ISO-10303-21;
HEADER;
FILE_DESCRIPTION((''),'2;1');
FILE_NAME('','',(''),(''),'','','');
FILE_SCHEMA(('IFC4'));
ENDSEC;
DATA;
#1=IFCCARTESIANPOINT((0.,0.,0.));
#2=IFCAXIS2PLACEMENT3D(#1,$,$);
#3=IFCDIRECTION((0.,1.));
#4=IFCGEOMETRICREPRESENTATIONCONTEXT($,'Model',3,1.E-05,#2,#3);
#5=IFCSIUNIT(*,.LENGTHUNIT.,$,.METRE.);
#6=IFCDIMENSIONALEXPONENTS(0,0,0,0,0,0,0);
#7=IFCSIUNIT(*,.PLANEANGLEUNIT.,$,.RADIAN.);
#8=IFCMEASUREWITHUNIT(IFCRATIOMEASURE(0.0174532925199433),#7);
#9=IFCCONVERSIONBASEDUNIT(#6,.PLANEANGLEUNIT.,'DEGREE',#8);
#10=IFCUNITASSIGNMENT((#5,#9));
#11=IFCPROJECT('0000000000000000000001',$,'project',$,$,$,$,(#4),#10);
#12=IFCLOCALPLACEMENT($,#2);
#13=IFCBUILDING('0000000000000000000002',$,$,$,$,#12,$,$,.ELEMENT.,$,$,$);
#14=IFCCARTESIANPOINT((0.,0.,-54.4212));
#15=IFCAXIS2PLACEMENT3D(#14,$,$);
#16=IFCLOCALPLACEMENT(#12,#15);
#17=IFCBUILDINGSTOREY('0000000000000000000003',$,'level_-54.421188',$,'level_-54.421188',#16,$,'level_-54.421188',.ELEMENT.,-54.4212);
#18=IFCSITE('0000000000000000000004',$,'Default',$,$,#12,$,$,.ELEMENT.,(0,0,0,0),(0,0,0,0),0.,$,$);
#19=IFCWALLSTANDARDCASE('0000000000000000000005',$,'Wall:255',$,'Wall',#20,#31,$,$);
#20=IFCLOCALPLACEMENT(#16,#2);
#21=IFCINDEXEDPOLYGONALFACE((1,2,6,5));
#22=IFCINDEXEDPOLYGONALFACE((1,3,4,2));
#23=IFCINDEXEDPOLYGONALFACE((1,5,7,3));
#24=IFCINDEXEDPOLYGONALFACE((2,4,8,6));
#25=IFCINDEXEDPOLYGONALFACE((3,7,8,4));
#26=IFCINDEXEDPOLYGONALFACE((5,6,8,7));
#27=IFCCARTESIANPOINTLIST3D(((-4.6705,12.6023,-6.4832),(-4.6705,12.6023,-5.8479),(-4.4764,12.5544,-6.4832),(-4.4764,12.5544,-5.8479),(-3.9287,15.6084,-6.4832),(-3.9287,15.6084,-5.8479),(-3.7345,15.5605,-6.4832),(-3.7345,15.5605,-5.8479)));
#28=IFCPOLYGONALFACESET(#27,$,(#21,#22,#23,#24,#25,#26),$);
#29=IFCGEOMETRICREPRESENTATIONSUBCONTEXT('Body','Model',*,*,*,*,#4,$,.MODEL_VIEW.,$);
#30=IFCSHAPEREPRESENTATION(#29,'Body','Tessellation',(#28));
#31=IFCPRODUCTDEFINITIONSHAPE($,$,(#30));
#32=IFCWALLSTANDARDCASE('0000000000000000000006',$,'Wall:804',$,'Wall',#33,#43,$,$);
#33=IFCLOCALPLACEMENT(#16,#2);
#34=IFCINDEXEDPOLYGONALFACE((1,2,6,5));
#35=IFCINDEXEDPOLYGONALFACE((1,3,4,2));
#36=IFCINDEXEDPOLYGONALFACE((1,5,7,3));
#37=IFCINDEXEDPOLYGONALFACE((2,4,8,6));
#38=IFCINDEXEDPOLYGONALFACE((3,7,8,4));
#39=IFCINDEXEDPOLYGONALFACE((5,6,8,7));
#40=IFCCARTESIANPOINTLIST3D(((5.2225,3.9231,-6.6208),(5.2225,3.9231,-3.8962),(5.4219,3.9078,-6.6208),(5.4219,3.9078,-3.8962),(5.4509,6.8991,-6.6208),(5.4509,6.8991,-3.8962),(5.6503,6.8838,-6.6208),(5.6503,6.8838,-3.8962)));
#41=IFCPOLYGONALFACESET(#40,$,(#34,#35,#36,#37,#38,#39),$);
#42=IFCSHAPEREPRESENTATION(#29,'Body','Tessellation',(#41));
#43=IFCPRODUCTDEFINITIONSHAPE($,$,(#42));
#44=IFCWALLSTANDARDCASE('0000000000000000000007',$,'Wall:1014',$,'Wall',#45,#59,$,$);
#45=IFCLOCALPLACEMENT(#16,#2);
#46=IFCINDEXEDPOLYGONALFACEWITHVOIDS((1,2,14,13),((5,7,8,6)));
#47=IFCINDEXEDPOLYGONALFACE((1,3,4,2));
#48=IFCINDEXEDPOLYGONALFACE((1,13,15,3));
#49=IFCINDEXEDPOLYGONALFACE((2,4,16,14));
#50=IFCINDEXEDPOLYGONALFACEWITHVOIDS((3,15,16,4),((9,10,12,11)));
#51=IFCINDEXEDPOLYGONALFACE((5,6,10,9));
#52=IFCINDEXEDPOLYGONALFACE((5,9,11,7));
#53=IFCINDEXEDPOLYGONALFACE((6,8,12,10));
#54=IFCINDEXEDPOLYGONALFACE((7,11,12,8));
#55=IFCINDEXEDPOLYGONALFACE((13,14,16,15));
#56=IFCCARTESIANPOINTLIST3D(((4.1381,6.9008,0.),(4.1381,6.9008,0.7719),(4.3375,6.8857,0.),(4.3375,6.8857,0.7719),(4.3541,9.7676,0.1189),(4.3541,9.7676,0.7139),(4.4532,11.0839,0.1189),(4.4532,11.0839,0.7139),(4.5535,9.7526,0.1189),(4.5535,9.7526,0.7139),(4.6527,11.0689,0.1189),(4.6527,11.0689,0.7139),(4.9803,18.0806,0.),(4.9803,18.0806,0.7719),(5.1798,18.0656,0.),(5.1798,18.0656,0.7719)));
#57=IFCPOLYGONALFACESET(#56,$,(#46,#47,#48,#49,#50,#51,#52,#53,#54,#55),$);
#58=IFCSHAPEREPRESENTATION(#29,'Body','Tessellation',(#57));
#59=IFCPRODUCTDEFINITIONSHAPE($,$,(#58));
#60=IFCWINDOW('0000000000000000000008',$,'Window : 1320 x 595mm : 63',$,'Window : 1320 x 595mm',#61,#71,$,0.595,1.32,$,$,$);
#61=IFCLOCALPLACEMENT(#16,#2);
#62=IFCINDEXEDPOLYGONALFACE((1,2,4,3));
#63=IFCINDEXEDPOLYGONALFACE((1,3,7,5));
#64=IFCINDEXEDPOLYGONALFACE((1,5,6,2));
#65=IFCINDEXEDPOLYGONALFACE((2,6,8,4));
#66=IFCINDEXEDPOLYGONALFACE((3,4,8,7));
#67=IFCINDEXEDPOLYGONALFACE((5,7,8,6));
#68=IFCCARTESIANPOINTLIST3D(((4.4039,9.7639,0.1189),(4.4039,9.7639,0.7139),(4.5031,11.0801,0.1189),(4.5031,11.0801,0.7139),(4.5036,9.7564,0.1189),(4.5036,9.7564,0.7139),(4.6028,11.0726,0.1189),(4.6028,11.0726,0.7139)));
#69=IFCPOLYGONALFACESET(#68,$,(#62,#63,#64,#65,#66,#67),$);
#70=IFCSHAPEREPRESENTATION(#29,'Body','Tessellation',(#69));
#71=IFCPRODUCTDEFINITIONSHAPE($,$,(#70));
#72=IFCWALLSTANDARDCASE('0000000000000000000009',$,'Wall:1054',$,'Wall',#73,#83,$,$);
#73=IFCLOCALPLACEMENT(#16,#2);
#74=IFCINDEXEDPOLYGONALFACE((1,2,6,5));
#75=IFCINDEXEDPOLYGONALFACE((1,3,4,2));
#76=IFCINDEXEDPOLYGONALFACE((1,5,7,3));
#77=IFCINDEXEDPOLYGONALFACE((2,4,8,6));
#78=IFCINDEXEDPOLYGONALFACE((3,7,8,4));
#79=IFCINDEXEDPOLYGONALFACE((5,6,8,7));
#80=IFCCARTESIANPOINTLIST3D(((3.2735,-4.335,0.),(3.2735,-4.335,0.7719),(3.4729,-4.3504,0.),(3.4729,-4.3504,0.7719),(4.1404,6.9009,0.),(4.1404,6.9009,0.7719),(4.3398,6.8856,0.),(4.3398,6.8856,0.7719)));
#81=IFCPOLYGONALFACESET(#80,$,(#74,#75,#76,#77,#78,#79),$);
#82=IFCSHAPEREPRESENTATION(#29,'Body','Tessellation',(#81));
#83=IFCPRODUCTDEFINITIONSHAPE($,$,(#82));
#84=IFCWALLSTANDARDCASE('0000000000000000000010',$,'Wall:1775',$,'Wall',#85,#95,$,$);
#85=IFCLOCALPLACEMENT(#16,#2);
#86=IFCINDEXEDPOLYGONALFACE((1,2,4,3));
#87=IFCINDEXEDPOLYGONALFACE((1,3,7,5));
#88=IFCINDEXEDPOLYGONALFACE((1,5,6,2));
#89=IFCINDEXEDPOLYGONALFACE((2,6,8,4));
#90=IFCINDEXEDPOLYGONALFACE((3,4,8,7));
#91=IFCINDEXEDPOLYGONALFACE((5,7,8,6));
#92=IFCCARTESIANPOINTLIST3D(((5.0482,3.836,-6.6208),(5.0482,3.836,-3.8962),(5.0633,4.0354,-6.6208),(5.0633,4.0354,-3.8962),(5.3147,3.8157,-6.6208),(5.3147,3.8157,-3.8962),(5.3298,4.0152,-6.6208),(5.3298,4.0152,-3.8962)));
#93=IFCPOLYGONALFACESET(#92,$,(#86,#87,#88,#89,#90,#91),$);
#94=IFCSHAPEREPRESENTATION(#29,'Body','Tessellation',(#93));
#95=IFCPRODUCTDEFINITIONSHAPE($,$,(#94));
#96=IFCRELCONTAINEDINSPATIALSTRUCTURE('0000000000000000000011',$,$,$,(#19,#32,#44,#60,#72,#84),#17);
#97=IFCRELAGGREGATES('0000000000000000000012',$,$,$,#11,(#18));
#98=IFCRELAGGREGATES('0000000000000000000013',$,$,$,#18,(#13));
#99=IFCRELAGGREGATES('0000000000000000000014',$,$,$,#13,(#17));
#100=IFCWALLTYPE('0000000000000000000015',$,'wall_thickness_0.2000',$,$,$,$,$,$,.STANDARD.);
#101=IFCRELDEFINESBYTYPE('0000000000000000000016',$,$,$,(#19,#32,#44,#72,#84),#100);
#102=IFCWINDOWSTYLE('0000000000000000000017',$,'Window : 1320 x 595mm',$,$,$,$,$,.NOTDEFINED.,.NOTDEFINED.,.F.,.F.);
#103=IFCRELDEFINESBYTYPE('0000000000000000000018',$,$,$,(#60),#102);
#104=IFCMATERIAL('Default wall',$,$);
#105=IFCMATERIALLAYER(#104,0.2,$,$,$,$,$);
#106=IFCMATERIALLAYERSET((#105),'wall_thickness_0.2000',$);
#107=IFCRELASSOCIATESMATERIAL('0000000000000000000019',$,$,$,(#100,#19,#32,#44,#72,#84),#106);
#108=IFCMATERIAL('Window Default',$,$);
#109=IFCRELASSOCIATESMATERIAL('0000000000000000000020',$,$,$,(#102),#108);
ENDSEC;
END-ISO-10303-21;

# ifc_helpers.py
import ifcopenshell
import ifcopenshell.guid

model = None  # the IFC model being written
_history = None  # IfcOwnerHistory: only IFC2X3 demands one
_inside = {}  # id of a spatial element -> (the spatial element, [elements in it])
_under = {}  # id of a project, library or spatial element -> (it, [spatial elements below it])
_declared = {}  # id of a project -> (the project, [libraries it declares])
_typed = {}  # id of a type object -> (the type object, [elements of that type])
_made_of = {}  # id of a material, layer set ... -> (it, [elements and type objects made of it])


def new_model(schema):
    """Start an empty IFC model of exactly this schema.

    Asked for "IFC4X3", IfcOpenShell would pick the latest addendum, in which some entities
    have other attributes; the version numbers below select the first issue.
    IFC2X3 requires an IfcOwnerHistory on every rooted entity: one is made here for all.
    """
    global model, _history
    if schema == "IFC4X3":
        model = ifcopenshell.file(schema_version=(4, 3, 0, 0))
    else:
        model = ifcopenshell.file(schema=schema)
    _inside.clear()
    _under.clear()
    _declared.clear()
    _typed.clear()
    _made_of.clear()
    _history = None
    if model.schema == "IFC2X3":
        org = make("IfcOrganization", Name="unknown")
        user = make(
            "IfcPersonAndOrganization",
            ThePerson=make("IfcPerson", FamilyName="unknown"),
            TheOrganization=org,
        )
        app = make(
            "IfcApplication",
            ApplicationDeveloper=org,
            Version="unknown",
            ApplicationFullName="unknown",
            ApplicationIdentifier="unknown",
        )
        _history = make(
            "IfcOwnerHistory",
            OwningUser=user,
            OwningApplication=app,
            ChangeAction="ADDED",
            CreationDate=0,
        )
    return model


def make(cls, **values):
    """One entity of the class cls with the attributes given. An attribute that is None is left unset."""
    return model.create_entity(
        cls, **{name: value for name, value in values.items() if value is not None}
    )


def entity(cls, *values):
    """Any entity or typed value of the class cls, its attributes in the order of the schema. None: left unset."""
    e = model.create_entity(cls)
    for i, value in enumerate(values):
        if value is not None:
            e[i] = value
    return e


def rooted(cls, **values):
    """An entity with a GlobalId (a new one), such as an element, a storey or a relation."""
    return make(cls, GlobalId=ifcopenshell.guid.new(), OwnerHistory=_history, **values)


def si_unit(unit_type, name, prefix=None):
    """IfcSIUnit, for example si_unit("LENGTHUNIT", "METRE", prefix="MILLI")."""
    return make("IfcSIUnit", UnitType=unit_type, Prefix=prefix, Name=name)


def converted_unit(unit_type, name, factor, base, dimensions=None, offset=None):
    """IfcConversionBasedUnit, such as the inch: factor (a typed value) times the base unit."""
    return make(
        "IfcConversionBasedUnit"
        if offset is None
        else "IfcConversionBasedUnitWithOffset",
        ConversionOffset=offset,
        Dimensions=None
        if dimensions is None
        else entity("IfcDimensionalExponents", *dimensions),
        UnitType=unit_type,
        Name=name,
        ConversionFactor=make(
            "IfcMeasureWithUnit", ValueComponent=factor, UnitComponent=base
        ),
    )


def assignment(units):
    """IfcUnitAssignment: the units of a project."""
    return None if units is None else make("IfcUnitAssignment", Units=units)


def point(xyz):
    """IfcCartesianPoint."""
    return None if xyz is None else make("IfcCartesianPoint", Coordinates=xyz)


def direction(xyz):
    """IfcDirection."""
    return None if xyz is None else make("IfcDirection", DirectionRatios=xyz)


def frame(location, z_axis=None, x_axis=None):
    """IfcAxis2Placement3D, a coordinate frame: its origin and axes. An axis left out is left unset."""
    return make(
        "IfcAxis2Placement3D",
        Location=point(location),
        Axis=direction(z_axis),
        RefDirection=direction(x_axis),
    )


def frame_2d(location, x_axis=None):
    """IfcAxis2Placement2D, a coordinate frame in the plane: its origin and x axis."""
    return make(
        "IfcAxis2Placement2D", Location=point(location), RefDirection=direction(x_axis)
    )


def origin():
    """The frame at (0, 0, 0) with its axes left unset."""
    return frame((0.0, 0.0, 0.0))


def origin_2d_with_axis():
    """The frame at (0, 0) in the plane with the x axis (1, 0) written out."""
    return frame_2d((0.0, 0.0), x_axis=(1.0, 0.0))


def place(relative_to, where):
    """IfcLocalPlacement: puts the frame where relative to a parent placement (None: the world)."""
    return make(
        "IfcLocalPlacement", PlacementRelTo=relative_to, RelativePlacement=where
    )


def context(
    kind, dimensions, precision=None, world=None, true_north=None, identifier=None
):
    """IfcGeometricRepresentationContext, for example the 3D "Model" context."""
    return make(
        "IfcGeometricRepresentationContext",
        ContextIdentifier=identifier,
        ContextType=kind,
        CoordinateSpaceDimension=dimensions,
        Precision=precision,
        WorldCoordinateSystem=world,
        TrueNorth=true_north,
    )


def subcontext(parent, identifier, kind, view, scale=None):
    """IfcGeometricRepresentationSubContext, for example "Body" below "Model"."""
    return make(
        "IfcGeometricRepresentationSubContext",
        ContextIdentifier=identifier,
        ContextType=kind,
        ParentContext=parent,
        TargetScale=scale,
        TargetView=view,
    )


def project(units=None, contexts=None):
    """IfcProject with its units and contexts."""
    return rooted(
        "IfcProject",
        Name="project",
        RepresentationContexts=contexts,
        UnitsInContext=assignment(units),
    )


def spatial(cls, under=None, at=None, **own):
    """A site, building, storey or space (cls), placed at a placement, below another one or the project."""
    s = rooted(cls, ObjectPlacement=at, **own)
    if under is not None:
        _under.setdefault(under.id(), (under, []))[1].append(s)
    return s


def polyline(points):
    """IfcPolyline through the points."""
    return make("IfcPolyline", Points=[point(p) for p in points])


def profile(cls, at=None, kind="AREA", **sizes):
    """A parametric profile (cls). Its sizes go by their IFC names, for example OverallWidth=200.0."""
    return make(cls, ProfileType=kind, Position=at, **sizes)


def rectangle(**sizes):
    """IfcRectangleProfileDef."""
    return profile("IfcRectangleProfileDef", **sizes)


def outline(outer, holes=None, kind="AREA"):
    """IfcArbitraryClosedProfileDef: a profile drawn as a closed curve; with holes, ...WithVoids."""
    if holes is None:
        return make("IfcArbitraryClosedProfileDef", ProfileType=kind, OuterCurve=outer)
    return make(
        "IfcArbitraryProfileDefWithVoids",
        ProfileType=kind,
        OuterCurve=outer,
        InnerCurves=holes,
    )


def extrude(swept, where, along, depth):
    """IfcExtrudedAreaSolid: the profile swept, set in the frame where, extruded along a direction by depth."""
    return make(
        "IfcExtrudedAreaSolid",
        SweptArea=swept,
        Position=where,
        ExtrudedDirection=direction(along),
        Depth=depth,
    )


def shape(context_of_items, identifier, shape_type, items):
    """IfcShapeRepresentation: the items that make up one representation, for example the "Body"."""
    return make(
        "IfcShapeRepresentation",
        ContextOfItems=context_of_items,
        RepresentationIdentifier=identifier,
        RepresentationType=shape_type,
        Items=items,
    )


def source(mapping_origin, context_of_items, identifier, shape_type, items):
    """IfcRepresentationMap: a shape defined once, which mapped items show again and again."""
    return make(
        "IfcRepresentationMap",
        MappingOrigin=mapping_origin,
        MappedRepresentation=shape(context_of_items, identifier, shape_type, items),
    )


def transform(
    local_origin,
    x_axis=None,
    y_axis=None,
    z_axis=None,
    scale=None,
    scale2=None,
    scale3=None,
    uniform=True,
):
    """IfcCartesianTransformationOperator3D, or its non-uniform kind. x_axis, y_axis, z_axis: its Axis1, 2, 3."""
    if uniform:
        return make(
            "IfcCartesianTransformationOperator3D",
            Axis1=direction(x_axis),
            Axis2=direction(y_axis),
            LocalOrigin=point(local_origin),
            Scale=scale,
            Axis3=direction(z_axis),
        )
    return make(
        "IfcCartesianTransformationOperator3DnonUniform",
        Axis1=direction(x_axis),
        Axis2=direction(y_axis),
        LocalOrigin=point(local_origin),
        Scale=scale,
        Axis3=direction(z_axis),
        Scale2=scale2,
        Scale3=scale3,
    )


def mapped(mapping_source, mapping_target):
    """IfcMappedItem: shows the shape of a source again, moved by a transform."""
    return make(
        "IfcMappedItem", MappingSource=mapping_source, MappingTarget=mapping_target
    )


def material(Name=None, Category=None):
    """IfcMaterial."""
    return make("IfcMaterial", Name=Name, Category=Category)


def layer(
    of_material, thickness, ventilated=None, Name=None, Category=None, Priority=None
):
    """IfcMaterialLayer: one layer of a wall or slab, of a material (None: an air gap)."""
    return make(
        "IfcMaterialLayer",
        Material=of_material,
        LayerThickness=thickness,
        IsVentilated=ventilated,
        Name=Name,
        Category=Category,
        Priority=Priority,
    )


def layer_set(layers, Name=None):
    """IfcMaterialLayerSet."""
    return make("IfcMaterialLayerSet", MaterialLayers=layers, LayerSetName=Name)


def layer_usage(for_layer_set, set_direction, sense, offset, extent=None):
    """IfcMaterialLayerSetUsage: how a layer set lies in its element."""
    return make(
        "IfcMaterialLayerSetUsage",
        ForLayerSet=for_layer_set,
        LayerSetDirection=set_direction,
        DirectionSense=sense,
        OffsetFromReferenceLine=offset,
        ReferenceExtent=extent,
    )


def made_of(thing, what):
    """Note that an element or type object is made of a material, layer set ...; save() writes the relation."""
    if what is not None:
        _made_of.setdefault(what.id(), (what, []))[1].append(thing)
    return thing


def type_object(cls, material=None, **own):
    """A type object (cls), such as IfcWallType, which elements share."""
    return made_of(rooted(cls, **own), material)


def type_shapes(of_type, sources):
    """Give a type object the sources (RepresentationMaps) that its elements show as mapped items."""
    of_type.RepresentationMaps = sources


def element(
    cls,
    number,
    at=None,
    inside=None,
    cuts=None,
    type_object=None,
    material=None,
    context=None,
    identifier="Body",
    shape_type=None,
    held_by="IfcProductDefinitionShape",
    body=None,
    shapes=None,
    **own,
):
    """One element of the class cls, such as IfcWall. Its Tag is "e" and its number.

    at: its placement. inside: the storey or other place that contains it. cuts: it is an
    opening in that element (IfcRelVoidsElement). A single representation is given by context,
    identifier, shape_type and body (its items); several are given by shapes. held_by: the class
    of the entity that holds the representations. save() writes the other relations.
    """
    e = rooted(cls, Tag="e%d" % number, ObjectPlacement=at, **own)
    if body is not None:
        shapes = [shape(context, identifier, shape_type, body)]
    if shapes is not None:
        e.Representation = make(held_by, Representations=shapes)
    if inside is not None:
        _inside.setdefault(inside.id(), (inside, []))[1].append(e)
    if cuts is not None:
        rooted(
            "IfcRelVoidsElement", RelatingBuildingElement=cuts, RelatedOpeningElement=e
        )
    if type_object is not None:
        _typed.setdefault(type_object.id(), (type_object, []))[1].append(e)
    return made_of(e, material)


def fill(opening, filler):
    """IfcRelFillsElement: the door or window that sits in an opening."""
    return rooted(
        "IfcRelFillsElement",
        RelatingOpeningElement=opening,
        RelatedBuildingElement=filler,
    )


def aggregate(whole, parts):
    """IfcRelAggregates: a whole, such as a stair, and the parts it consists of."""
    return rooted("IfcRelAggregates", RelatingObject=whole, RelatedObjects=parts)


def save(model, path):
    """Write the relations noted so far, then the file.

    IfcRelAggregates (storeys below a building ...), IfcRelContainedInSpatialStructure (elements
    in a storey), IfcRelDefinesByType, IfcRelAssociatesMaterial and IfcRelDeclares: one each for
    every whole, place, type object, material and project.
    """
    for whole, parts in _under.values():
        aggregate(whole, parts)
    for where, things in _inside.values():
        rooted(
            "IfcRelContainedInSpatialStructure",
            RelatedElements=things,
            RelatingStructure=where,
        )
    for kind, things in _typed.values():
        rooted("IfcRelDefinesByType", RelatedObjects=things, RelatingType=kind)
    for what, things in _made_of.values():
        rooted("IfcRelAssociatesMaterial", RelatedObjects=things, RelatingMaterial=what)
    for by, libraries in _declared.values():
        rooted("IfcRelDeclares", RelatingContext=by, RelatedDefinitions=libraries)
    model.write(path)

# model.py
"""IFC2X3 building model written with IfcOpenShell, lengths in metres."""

from ifc_helpers import new_model, entity, si_unit, converted_unit, direction, frame, frame_2d, origin, origin_2d_with_axis, place, context, subcontext, project, spatial, polyline, rectangle, outline, extrude, source, transform, mapped, material, layer, layer_set, layer_usage, type_object, type_shapes, element, fill, save


model = new_model("IFC2X3")

# Units and contexts
model_context = context("Model", 3, precision=1e-05, world=origin(), true_north=direction((0.0, 1.0)))
body_context = subcontext(model_context, "Body", "Model", "MODEL_VIEW")
ifc_project = project(units=[si_unit("LENGTHUNIT", "METRE"), converted_unit("PLANEANGLEUNIT", "DEGREE", entity("IfcRatioMeasure", 0.0174532925199433), si_unit("PLANEANGLEUNIT", "RADIAN"), dimensions=[0, 0, 0, 0, 0, 0, 0])], contexts=[model_context])

# Site, building, storey
placement_1 = place(None, origin())
site = spatial("IfcSite", under=ifc_project, at=placement_1, Name="Default", CompositionType="ELEMENT", RefLatitude=(0, 0, 0, 0), RefLongitude=(0, 0, 0, 0), RefElevation=0.0)
building = spatial("IfcBuilding", under=site, at=placement_1, CompositionType="ELEMENT")
storey_placement = place(placement_1, frame((0.0, 0.0, -54.4212)))
storey = spatial("IfcBuildingStorey", under=building, at=storey_placement, Name="level_-54.421188", ObjectType="level_-54.421188", LongName="level_-54.421188", CompositionType="ELEMENT", Elevation=-54.4212)

# Wall
ifc_material_1 = material(Name="Default wall")
ifc_layer = layer(ifc_material_1, 0.2)
ifc_layer_set = layer_set([ifc_layer], Name="wall_thickness_0.2000")
ifc_layer_usage = layer_usage(ifc_layer_set, "AXIS2", "POSITIVE", -0.1)
wall_type = type_object("IfcWallType", Name="wall_thickness_0.2000", PredefinedType="STANDARD", material=ifc_layer_set)
placement_2 = place(placement_1, frame((0.0, 0.0, -60.9044)))
wall_1_placement = place(placement_2, frame((-4.5734, 12.5783, 0.0), z_axis=(0.0, 0.0, 1.0), x_axis=(0.239603, 0.970871, 0.0)))
element("IfcWallStandardCase", 1, at=wall_1_placement, inside=storey, type_object=wall_type, material=ifc_layer_usage, Name="Wall:255", ObjectType="Wall", context=body_context, shape_type="SweptSolid", body=[
    extrude(outline(polyline([(3.0963, -0.1), (3.0963, 0.1), (0.0, 0.1), (0.0, -0.1), (3.0963, -0.1)])), origin(), (0.0, 0.0, 1.0), 0.6353),
])

# Shared definitions
ifc_material_2 = material(Name="Window Default")

# Wall
placement_3 = place(placement_1, frame((0.0, 0.0, -61.042)))
wall_2_placement = place(placement_3, frame((5.3222, 3.9155, 0.0), z_axis=(0.0, 0.0, 1.0), x_axis=(0.076502, 0.997069, 0.0)))
element("IfcWallStandardCase", 2, at=wall_2_placement, inside=storey, type_object=wall_type, material=ifc_layer_usage, Name="Wall:804", ObjectType="Wall", context=body_context, shape_type="SweptSolid", body=[
    extrude(outline(polyline([(2.9848, -0.1), (2.9848, 0.1), (0.0, 0.1), (0.0, -0.1), (2.9848, -0.1)])), origin(), (0.0, 0.0, 1.0), 2.7247),
])

# Wall, opening, window
wall_3_placement = place(storey_placement, frame((4.2378, 6.8932, 0.0), z_axis=(0.0, 0.0, 1.0), x_axis=(0.075126, 0.997174, 0.0)))
wall_3 = element("IfcWallStandardCase", 3, at=wall_3_placement, inside=storey, type_object=wall_type, material=ifc_layer_usage, Name="Wall:1014", ObjectType="Wall", context=body_context, shape_type="SweptSolid", body=[
    extrude(outline(polyline([(11.2116, -0.1), (11.2116, 0.1), (0.0, 0.1), (0.0, -0.1), (11.2116, -0.1)])), origin(), (0.0, 0.0, 1.0), 0.7719),
])
opening_1_placement = place(wall_3_placement, frame((2.875, -0.1, 0.1189)))
opening_1 = element("IfcOpeningElement", 4, at=opening_1_placement, cuts=wall_3, ObjectType="Opening", context=body_context, shape_type="SweptSolid", body=[
    extrude(rectangle(XDim=1.32, YDim=0.595, at=frame_2d((0.2975, 0.66), x_axis=(0.0, 1.0))), frame((0.0, 0.0, 0.0), z_axis=(0.0, 1.0, 0.0), x_axis=(0.0, 0.0, 1.0)), (0.0, 0.0, 1.0), 0.2),
])
window_style_1 = type_object("IfcWindowStyle", Name="Window : 1320 x 595mm", ConstructionType="NOTDEFINED", OperationType="NOTDEFINED", ParameterTakesPrecedence=False, Sizeable=False, material=ifc_material_2)
shared_shape_1 = source(origin(), body_context, "Body", "SweptSolid", [
    extrude(rectangle(XDim=0.1, YDim=1.32, at=origin_2d_with_axis()), frame((0.66, 0.1, 0.0), z_axis=(0.0, 0.0, 1.0), x_axis=(0.0, 1.0, 0.0)), (0.0, 0.0, 1.0), 0.595),
])
type_shapes(window_style_1, [shared_shape_1])
window_1_placement = place(opening_1_placement, origin())
window_1 = element("IfcWindow", 5, at=window_1_placement, inside=storey, type_object=window_style_1, Name="Window : 1320 x 595mm : 63", ObjectType="Window : 1320 x 595mm", OverallHeight=0.595, OverallWidth=1.32, context=body_context, shape_type="MappedRepresentation", body=[
    mapped(shared_shape_1, transform((0.0, 0.0, 0.0), scale=1.0)),
])
fill(opening_1, window_1)

# Walls
wall_4_placement = place(storey_placement, frame((3.3732, -4.3427, 0.0), z_axis=(0.0, 0.0, 1.0), x_axis=(0.076932, 0.997036, 0.0)))
element("IfcWallStandardCase", 6, at=wall_4_placement, inside=storey, type_object=wall_type, material=ifc_layer_usage, Name="Wall:1054", ObjectType="Wall", context=body_context, shape_type="SweptSolid", body=[
    extrude(outline(polyline([(11.2694, -0.1), (11.2694, 0.1), (0.0, 0.1), (0.0, -0.1), (11.2694, -0.1)])), origin(), (0.0, 0.0, 1.0), 0.7719),
])
placement_4 = place(placement_1, frame((0.0, 0.0, -61.042)))
wall_5_placement = place(placement_4, frame((5.3222, 3.9155, 0.0), z_axis=(0.0, 0.0, 1.0), x_axis=(-0.997132, 0.075687, 0.0)))
element("IfcWallStandardCase", 7, at=wall_5_placement, inside=storey, type_object=wall_type, material=ifc_layer_usage, Name="Wall:1775", ObjectType="Wall", context=body_context, shape_type="SweptSolid", body=[
    extrude(outline(polyline([(0.2672, -0.1), (0.2672, 0.1), (0.0, 0.1), (0.0, -0.1), (0.2672, -0.1)])), origin(), (0.0, 0.0, 1.0), 2.7247),
])

save(model, "model.ifc")
